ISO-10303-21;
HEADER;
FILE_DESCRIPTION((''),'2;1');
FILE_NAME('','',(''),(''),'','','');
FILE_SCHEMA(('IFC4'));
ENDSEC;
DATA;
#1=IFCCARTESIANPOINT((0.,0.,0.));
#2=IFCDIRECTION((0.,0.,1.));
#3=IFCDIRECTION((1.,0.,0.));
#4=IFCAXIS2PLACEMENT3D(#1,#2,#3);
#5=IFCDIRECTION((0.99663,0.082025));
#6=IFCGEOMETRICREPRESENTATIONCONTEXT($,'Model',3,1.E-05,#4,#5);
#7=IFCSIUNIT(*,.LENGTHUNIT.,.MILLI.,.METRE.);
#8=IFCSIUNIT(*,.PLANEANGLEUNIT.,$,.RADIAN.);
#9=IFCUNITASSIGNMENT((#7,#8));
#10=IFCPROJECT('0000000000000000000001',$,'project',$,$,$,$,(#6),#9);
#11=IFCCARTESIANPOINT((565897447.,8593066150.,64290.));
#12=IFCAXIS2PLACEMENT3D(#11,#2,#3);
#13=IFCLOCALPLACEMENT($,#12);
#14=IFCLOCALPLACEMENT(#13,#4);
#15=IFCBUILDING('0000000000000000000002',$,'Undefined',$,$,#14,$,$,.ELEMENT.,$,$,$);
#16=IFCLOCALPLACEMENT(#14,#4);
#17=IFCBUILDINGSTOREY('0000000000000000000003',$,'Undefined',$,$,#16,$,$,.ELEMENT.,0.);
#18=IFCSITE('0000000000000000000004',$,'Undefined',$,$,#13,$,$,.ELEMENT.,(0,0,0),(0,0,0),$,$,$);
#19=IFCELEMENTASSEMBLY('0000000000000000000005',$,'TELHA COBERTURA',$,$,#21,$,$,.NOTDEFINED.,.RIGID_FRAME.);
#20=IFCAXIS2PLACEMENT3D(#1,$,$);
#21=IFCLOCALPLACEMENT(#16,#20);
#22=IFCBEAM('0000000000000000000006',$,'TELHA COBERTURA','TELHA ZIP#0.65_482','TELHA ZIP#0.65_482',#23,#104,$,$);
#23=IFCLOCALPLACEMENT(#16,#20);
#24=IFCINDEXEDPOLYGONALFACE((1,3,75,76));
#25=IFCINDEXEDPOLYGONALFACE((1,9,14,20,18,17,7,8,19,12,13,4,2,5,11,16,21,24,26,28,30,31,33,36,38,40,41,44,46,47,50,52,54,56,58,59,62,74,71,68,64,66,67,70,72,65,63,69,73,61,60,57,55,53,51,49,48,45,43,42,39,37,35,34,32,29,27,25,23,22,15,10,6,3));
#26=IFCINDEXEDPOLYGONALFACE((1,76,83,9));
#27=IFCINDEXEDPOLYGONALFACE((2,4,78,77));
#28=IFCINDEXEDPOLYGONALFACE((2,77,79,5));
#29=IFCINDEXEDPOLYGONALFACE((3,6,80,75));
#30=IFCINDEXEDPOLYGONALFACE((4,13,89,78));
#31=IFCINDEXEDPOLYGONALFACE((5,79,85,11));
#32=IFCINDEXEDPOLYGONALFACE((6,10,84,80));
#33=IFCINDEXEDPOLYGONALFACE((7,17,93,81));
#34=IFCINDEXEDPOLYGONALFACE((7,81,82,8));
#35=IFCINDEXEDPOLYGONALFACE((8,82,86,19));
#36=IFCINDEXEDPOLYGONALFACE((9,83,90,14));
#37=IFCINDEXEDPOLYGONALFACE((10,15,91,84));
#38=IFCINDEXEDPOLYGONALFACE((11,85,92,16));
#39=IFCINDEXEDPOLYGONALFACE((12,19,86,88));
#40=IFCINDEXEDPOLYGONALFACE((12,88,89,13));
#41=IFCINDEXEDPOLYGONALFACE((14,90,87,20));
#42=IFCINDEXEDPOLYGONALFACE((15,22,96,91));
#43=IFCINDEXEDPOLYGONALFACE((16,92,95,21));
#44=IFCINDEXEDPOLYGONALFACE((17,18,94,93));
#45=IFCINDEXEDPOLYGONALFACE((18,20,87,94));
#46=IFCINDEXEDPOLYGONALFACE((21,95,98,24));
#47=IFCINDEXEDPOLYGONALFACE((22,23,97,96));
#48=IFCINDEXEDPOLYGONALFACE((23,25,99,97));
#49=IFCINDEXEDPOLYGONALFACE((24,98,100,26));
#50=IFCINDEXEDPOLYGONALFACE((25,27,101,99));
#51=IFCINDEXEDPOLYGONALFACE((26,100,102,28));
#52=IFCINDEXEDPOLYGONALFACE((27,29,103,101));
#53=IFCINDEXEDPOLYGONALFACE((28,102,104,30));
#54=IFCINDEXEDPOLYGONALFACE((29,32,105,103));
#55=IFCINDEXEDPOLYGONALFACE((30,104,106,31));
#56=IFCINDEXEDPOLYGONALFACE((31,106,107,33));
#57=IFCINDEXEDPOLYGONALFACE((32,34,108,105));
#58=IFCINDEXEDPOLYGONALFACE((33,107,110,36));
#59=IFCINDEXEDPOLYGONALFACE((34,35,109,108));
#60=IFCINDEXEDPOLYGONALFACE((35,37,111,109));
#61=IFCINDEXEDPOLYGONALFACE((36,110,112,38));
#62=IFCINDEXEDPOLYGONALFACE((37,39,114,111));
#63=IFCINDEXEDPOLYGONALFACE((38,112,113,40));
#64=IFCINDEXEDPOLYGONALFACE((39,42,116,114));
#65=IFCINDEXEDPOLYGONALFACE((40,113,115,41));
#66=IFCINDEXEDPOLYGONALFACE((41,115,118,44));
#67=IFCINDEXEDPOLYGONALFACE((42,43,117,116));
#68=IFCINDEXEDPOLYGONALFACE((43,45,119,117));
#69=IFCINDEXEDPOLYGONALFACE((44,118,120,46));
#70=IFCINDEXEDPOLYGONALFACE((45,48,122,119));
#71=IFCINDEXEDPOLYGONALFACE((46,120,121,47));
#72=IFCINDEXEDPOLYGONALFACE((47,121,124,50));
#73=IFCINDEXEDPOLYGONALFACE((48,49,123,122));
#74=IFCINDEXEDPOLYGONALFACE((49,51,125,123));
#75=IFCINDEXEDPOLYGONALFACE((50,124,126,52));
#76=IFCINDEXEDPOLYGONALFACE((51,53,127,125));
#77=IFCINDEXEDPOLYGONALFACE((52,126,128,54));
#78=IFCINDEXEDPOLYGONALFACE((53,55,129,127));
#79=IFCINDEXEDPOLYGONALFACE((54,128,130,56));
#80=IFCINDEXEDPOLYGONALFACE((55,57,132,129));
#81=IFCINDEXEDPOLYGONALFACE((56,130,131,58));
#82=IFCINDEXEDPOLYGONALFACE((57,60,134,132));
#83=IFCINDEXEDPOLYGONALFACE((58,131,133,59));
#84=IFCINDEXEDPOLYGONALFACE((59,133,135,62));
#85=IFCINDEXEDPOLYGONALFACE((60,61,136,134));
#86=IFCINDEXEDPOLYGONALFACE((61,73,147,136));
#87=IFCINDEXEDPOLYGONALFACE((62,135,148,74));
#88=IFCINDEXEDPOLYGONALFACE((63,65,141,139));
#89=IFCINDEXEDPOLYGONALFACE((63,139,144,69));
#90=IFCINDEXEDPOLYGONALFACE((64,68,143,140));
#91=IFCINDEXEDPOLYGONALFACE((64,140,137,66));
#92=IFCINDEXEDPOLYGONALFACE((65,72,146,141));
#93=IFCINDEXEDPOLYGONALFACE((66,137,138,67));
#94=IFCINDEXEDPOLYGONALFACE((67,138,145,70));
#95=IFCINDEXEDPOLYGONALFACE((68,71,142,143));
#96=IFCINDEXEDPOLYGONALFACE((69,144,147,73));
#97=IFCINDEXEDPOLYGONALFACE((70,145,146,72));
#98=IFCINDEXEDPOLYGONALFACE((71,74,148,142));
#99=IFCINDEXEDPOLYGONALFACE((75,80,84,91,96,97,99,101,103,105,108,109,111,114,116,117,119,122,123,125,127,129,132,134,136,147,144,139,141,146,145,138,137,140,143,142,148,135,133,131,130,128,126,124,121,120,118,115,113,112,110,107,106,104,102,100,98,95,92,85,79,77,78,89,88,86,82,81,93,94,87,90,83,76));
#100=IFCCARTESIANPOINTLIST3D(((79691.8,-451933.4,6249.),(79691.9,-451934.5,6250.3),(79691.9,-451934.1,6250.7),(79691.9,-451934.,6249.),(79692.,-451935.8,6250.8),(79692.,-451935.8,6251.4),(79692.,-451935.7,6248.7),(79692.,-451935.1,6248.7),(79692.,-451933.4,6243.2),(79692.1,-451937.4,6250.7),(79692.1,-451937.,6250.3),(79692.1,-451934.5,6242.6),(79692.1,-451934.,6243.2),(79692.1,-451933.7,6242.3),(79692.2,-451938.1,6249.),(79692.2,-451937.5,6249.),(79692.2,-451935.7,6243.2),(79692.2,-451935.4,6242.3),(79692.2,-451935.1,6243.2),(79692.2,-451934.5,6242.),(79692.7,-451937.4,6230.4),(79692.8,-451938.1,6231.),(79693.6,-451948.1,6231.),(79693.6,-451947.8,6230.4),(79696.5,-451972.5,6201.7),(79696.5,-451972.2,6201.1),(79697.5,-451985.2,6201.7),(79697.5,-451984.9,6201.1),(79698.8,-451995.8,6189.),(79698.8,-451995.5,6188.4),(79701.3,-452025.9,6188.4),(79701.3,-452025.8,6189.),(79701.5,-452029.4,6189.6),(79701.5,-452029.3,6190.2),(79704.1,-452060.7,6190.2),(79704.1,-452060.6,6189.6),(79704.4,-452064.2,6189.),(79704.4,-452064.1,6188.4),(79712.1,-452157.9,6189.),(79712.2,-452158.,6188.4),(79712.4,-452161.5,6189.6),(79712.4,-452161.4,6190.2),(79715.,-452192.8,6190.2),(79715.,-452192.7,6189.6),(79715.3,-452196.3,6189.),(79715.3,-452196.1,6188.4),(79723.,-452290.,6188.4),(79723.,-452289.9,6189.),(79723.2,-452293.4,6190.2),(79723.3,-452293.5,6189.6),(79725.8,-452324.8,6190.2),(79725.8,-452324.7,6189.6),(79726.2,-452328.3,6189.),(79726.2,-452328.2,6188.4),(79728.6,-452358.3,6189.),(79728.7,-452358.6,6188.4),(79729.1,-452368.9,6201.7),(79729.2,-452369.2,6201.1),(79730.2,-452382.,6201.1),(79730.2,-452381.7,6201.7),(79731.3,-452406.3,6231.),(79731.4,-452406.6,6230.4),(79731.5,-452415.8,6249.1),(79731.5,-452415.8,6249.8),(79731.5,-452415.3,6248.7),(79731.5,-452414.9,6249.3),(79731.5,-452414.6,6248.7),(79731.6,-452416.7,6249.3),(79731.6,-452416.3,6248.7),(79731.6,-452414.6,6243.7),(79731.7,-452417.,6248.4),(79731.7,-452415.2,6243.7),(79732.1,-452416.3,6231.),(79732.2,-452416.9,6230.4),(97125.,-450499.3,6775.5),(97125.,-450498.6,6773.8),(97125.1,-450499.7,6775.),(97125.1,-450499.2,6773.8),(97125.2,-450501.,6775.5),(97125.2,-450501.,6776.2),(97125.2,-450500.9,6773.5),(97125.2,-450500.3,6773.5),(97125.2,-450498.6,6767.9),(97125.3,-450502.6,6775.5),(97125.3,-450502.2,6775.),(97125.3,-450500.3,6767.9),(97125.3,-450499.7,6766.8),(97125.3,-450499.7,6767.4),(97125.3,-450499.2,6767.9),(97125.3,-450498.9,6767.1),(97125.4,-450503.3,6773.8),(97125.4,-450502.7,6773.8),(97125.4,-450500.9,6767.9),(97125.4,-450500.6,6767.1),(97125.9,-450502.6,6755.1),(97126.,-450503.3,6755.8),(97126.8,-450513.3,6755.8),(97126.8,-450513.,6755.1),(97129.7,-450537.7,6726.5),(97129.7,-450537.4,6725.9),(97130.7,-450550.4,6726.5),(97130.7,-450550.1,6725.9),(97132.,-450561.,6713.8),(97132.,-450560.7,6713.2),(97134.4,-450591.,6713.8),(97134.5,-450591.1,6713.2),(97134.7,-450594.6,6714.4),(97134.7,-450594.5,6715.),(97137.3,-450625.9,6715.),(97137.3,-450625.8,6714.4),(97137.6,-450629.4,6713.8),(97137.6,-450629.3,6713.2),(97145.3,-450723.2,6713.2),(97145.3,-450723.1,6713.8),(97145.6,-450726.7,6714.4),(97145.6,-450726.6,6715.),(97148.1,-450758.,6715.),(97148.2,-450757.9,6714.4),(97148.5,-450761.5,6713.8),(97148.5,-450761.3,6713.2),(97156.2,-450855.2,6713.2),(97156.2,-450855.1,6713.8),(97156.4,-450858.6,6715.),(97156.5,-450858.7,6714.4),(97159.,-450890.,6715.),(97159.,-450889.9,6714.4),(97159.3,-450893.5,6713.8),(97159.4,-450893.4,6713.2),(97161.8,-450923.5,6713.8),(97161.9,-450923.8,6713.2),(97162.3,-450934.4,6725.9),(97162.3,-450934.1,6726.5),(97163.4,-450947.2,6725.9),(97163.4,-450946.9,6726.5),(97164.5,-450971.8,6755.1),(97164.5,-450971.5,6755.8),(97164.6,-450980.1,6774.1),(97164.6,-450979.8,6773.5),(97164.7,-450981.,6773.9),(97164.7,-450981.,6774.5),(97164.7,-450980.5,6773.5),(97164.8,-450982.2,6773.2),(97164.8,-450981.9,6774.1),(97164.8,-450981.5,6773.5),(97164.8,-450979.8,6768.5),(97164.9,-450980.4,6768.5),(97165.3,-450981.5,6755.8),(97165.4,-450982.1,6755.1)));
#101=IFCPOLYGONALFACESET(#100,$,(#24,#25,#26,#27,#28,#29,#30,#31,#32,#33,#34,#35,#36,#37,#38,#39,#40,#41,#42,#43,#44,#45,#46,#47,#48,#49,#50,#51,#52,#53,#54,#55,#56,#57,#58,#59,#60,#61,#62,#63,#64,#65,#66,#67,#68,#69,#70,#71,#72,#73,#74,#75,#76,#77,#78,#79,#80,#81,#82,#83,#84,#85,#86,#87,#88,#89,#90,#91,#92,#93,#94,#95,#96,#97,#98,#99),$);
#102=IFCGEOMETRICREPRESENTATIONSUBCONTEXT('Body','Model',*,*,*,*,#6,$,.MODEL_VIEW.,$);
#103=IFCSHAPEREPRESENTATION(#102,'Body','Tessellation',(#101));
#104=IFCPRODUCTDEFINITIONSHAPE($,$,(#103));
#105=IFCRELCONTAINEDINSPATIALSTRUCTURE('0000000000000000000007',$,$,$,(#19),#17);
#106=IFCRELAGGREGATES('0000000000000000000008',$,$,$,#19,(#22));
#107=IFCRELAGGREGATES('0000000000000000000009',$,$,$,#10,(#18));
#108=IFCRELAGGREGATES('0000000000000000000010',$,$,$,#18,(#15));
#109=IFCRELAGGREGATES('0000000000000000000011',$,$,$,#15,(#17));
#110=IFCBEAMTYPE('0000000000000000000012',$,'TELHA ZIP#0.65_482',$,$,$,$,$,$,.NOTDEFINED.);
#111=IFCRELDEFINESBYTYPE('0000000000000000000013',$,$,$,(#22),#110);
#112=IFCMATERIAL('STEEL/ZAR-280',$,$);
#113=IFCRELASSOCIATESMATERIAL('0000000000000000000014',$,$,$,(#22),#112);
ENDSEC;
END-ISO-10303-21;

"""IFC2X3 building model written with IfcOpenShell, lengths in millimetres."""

from ifc_helpers import new_model, si_unit, direction, frame, origin_with_axes, place, context, subcontext, project, spatial, polyline, outline, extrude, material, type_object, element, aggregate, save


model = new_model("IFC2X3")

# Units and contexts
model_context = context("Model", 3, precision=1e-05, world=origin_with_axes(), true_north=direction((0.99663, 0.082025)))
body_context = subcontext(model_context, "Body", "Model", "MODEL_VIEW")
ifc_project = project(units=[si_unit("LENGTHUNIT", "METRE", prefix="MILLI"), si_unit("PLANEANGLEUNIT", "RADIAN")], contexts=[model_context])

# Site, building, storey
site_placement = place(None, frame((565897447.0, 8593066150.0, 64290.0), z_axis=(0.0, 0.0, 1.0), x_axis=(1.0, 0.0, 0.0)))
site = spatial("IfcSite", under=ifc_project, at=site_placement, Name="Undefined", CompositionType="ELEMENT", RefLatitude=(0, 0, 0), RefLongitude=(0, 0, 0))
building_placement = place(site_placement, origin_with_axes())
building = spatial("IfcBuilding", under=site, at=building_placement, Name="Undefined", CompositionType="ELEMENT")
storey_placement = place(building_placement, origin_with_axes())
storey = spatial("IfcBuildingStorey", under=building, at=storey_placement, Name="Undefined", CompositionType="ELEMENT", Elevation=0.0)

# Element assembly, beam
assembly_1_placement = place(storey_placement, origin_with_axes())
assembly_1 = element("IfcElementAssembly", 1, at=assembly_1_placement, inside=storey, Name="TELHA COBERTURA", AssemblyPlace="NOTDEFINED", PredefinedType="RIGID_FRAME")
ifc_material_1 = material(Name="STEEL/ZAR-280")
beam_type_1 = type_object("IfcBeamType", Name="TELHA ZIP#0.65_482", PredefinedType="NOTDEFINED")
beam_1_placement = place(assembly_1_placement, frame((79712.6, -452175.1, 6219.6), z_axis=(-0.029885, -0.00246, 0.99955), x_axis=(0.996182, 0.081989, 0.029987)))
beam_1 = element("IfcBeam", 2, at=beam_1_placement, type_object=beam_type_1, material=ifc_material_1, Name="TELHA COBERTURA", Description="TELHA ZIP#0.65_482", ObjectType="TELHA ZIP#0.65_482", context=body_context, shape_type="SweptSolid", body=[
    extrude(outline(polyline([(240.5, 29.7), (241.4, 30.2), (242.4, 29.7), (242.6, 28.9), (242.6, 10.8), (232.2, 10.8), (207.6, -18.5), (194.9, -18.5), (184.2, -31.2), (153.7, -31.2), (150.2, -30.0), (118.9, -30.0), (115.4, -31.2), (21.2, -31.2), (17.7, -30.0), (-13.6, -30.0), (-17.1, -31.2), (-111.3, -31.2), (-114.8, -30.0), (-146.1, -30.0), (-149.6, -31.2), (-180.1, -31.2), (-190.8, -18.5), (-203.6, -18.5), (-228.1, 10.8), (-238.5, 10.8), (-238.5, 29.5), (-239.0, 30.7), (-240.2, 31.2), (-241.4, 30.7), (-241.9, 29.5), (-241.9, 23.6), (-241.4, 23.1), (-240.9, 23.6), (-240.9, 29.1), (-240.2, 29.1), (-240.2, 23.6), (-240.6, 22.8), (-241.4, 22.4), (-242.3, 22.8), (-242.6, 23.6), (-242.6, 29.5), (-241.9, 31.2), (-240.2, 31.9), (-238.5, 31.2), (-237.9, 29.5), (-237.9, 11.4), (-227.8, 11.4), (-203.2, -17.9), (-190.4, -17.9), (-179.8, -30.5), (-149.7, -30.5), (-146.2, -29.4), (-114.7, -29.4), (-111.2, -30.5), (-17.2, -30.5), (-13.7, -29.4), (17.8, -29.4), (21.3, -30.5), (115.3, -30.5), (118.8, -29.4), (150.3, -29.4), (153.8, -30.5), (183.9, -30.5), (194.6, -17.9), (207.4, -17.9), (231.9, 11.4), (241.9, 11.4), (241.9, 29.1), (241.4, 29.5), (240.9, 29.1), (240.9, 24.1), (240.2, 24.1), (240.2, 29.2), (240.5, 29.7)])), frame((17500.0, 0.0, 0.0), z_axis=(-1.0, 0.0, 0.0), x_axis=(0.0, -1.0, 0.0)), (0.0, 0.0, 1.0), 17500.0),
])
aggregate(assembly_1, [beam_1])

save(model, "model.ifc")
